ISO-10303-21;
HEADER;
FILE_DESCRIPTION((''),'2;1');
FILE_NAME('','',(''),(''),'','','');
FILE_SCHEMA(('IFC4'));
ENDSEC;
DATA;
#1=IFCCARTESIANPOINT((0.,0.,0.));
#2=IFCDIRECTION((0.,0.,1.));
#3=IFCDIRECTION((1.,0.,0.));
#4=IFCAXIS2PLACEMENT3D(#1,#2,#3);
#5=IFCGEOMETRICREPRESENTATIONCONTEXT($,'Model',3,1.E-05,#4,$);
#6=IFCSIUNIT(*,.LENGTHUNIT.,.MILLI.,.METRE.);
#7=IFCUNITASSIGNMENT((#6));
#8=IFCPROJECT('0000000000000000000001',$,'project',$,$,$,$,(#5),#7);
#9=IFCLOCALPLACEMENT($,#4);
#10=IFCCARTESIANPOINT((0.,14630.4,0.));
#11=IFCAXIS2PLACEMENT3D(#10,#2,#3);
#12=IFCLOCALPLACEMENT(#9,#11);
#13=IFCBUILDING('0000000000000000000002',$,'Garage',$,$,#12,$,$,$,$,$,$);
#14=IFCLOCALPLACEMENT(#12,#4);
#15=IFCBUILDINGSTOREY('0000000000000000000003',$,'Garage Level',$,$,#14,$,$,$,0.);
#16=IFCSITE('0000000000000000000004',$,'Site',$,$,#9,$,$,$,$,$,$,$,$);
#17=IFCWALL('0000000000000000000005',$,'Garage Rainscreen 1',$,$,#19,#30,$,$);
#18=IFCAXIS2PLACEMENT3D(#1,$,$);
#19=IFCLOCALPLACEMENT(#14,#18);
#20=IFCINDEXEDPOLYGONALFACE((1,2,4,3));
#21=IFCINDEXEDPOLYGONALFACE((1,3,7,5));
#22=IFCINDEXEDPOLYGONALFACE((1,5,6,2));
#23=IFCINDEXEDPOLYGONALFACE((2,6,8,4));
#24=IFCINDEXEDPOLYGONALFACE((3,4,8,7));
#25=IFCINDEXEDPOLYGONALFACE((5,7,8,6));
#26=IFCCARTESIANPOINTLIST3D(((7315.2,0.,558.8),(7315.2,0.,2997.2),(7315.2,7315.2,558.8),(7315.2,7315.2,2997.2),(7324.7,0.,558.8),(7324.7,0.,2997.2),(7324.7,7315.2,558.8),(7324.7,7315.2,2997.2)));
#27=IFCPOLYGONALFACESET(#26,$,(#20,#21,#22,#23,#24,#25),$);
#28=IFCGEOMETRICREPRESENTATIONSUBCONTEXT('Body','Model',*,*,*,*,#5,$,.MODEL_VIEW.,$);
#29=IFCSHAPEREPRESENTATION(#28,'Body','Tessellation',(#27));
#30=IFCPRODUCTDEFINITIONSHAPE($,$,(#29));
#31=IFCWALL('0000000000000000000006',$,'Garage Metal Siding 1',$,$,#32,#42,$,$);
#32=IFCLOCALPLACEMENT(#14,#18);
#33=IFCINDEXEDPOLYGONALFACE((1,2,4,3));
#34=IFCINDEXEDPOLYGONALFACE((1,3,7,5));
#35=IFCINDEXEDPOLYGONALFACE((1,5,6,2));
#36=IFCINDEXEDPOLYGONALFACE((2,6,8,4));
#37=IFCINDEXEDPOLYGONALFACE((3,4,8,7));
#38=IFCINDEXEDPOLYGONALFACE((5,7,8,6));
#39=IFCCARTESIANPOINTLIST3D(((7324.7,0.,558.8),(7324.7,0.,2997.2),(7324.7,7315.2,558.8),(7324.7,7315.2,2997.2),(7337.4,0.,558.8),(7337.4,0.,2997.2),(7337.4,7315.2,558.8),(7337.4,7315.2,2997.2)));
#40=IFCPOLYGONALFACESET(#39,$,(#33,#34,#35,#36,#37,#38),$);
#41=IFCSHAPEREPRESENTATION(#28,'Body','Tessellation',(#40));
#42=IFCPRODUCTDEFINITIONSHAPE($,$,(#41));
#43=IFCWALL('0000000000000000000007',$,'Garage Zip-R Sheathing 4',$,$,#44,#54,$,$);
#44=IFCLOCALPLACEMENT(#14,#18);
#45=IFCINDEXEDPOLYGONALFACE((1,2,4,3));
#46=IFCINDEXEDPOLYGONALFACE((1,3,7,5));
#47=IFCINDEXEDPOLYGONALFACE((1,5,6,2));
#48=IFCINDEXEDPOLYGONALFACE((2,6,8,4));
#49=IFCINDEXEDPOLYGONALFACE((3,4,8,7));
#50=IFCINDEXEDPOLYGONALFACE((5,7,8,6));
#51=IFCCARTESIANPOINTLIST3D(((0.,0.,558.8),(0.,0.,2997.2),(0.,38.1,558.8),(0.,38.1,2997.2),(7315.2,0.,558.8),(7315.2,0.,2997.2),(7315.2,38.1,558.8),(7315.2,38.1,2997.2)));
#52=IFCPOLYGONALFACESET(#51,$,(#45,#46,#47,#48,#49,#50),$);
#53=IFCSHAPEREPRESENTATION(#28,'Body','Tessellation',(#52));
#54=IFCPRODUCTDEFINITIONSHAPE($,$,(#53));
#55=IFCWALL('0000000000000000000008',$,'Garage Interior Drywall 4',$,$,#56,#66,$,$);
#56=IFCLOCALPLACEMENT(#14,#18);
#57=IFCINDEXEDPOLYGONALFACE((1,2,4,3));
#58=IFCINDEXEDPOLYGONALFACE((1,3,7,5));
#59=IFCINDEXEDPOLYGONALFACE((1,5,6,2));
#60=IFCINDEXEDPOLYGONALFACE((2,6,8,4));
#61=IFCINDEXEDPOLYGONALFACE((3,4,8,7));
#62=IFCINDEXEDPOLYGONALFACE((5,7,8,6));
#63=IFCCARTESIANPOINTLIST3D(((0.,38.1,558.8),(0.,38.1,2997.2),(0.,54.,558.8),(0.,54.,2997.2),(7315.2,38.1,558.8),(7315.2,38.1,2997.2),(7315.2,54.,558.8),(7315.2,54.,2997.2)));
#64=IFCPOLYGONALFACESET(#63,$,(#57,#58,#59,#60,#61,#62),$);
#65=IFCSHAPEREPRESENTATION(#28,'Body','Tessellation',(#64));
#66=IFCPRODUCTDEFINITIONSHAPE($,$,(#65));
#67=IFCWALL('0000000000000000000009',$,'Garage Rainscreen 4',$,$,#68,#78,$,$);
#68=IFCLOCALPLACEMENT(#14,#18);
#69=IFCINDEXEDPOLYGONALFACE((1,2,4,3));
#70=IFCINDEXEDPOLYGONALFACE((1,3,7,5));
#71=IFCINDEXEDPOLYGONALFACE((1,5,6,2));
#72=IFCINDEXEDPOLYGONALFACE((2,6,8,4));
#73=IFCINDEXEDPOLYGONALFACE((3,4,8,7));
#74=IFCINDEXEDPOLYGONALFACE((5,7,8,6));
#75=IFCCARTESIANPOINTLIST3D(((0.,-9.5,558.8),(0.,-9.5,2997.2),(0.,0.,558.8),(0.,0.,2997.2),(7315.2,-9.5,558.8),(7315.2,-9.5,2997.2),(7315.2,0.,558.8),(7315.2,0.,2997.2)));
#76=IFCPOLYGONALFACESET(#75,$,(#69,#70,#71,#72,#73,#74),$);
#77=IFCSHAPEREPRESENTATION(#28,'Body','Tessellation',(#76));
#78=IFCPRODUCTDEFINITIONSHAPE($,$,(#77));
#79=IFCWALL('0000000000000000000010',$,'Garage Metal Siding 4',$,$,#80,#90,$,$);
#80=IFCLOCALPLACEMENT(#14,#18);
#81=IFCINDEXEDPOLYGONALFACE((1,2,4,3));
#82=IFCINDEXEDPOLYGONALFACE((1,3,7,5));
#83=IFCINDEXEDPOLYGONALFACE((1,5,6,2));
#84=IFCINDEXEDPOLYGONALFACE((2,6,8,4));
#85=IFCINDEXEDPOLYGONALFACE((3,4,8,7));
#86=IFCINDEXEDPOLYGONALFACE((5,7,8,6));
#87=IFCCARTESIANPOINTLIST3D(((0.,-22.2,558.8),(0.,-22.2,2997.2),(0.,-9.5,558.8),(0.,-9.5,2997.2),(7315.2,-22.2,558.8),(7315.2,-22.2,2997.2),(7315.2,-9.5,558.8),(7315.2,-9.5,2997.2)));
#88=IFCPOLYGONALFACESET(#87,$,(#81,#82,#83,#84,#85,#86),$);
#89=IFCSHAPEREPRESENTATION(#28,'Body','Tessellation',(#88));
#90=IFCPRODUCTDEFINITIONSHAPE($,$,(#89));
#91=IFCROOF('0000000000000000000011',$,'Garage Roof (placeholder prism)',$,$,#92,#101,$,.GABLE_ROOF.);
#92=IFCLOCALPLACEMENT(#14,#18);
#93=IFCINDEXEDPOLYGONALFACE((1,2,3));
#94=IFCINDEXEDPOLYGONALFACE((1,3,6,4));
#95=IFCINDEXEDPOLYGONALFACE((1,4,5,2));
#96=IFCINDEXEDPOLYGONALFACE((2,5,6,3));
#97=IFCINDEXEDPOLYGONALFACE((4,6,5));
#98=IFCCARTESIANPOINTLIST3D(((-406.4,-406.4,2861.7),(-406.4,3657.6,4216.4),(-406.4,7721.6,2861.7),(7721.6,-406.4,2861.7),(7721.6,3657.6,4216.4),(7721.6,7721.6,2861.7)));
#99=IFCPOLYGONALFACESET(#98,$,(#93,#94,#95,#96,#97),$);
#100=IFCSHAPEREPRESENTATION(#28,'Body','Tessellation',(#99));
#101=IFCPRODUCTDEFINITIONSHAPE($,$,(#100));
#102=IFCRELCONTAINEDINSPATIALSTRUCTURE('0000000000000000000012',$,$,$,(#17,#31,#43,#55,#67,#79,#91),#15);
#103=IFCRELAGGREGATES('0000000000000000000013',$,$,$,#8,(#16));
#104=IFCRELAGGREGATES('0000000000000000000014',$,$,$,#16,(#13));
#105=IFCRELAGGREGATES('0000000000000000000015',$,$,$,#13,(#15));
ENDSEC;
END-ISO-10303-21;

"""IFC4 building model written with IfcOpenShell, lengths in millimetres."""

from ifc_helpers import new_model, si_unit, frame, origin_with_axes, place, context, subcontext, project, spatial, indexed_curve, outline, extrude, element, save


model = new_model("IFC4")

# Units and contexts
model_context = context("Model", 3, precision=1e-05, world=origin_with_axes())
body_context = subcontext(model_context, "Body", "Model", "MODEL_VIEW")
ifc_project = project(units=[si_unit("LENGTHUNIT", "METRE", prefix="MILLI")], contexts=[model_context])

# Site, building, storey
site_placement = place(None, origin_with_axes())
site = spatial("IfcSite", under=ifc_project, at=site_placement, Name="Site")
building_placement = place(site_placement, frame((0.0, 14630.4, 0.0), z_axis=(0.0, 0.0, 1.0), x_axis=(1.0, 0.0, 0.0)))
building = spatial("IfcBuilding", under=site, at=building_placement, Name="Garage")
storey_placement = place(building_placement, origin_with_axes())
storey = spatial("IfcBuildingStorey", under=building, at=storey_placement, Name="Garage Level", Elevation=0.0)

# Walls
wall_1_placement = place(storey_placement, frame((7315.2, 0.0, 558.8), z_axis=(0.0, 0.0, 1.0), x_axis=(0.0, 1.0, 0.0)))
element("IfcWall", 1, at=wall_1_placement, inside=storey, Name="Garage Rainscreen 1", context=body_context, shape_type="SweptSolid", body=[
    extrude(outline(indexed_curve([(0.0, 0.0), (0.0, -9.5), (7315.2, -9.5), (7315.2, 0.0), (0.0, 0.0)], self_intersect=False)), origin_with_axes(), (0.0, 0.0, 1.0), 2438.4),
])
wall_2_placement = place(storey_placement, frame((7315.2, 0.0, 558.8), z_axis=(0.0, 0.0, 1.0), x_axis=(0.0, 1.0, 0.0)))
element("IfcWall", 2, at=wall_2_placement, inside=storey, Name="Garage Metal Siding 1", context=body_context, shape_type="SweptSolid", body=[
    extrude(outline(indexed_curve([(0.0, 0.0), (0.0, -12.7), (7315.2, -12.7), (7315.2, 0.0), (0.0, 0.0)], self_intersect=False)), frame((0.0, -9.5, 0.0), z_axis=(0.0, 0.0, 1.0), x_axis=(1.0, 0.0, 0.0)), (0.0, 0.0, 1.0), 2438.4),
])
wall_3_placement = place(storey_placement, frame((0.0, 0.0, 558.8), z_axis=(0.0, 0.0, 1.0), x_axis=(1.0, 0.0, 0.0)))
element("IfcWall", 3, at=wall_3_placement, inside=storey, Name="Garage Zip-R Sheathing 4", context=body_context, shape_type="SweptSolid", body=[
    extrude(outline(indexed_curve([(0.0, 0.0), (0.0, 38.1), (7315.2, 38.1), (7315.2, 0.0), (0.0, 0.0)], self_intersect=False)), origin_with_axes(), (0.0, 0.0, 1.0), 2438.4),
])
wall_4_placement = place(storey_placement, frame((0.0, 0.0, 558.8), z_axis=(0.0, 0.0, 1.0), x_axis=(1.0, 0.0, 0.0)))
element("IfcWall", 4, at=wall_4_placement, inside=storey, Name="Garage Interior Drywall 4", context=body_context, shape_type="SweptSolid", body=[
    extrude(outline(indexed_curve([(0.0, 0.0), (0.0, 15.9), (7315.2, 15.9), (7315.2, 0.0), (0.0, 0.0)], self_intersect=False)), frame((0.0, 38.1, 0.0), z_axis=(0.0, 0.0, 1.0), x_axis=(1.0, 0.0, 0.0)), (0.0, 0.0, 1.0), 2438.4),
])
wall_5_placement = place(storey_placement, frame((0.0, 0.0, 558.8), z_axis=(0.0, 0.0, 1.0), x_axis=(1.0, 0.0, 0.0)))
element("IfcWall", 5, at=wall_5_placement, inside=storey, Name="Garage Rainscreen 4", context=body_context, shape_type="SweptSolid", body=[
    extrude(outline(indexed_curve([(0.0, 0.0), (0.0, -9.5), (7315.2, -9.5), (7315.2, 0.0), (0.0, 0.0)], self_intersect=False)), origin_with_axes(), (0.0, 0.0, 1.0), 2438.4),
])
wall_6_placement = place(storey_placement, frame((0.0, 0.0, 558.8), z_axis=(0.0, 0.0, 1.0), x_axis=(1.0, 0.0, 0.0)))
element("IfcWall", 6, at=wall_6_placement, inside=storey, Name="Garage Metal Siding 4", context=body_context, shape_type="SweptSolid", body=[
    extrude(outline(indexed_curve([(0.0, 0.0), (0.0, -12.7), (7315.2, -12.7), (7315.2, 0.0), (0.0, 0.0)], self_intersect=False)), frame((0.0, -9.5, 0.0), z_axis=(0.0, 0.0, 1.0), x_axis=(1.0, 0.0, 0.0)), (0.0, 0.0, 1.0), 2438.4),
])

# Roof
roof_placement = place(storey_placement, frame((-406.4, 0.0, 2861.7), z_axis=(1.0, 0.0, 0.0), x_axis=(0.0, 1.0, 0.0)))
element("IfcRoof", 7, at=roof_placement, inside=storey, Name="Garage Roof (placeholder prism)", PredefinedType="GABLE_ROOF", context=body_context, shape_type="SweptSolid", body=[
    extrude(outline(indexed_curve([(-406.4, 0.0), (3657.6, 1354.7), (7721.6, 0.0), (-406.4, 0.0)])), origin_with_axes(), (0.0, 0.0, 1.0), 8128.0),
])

save(model, "model.ifc")
